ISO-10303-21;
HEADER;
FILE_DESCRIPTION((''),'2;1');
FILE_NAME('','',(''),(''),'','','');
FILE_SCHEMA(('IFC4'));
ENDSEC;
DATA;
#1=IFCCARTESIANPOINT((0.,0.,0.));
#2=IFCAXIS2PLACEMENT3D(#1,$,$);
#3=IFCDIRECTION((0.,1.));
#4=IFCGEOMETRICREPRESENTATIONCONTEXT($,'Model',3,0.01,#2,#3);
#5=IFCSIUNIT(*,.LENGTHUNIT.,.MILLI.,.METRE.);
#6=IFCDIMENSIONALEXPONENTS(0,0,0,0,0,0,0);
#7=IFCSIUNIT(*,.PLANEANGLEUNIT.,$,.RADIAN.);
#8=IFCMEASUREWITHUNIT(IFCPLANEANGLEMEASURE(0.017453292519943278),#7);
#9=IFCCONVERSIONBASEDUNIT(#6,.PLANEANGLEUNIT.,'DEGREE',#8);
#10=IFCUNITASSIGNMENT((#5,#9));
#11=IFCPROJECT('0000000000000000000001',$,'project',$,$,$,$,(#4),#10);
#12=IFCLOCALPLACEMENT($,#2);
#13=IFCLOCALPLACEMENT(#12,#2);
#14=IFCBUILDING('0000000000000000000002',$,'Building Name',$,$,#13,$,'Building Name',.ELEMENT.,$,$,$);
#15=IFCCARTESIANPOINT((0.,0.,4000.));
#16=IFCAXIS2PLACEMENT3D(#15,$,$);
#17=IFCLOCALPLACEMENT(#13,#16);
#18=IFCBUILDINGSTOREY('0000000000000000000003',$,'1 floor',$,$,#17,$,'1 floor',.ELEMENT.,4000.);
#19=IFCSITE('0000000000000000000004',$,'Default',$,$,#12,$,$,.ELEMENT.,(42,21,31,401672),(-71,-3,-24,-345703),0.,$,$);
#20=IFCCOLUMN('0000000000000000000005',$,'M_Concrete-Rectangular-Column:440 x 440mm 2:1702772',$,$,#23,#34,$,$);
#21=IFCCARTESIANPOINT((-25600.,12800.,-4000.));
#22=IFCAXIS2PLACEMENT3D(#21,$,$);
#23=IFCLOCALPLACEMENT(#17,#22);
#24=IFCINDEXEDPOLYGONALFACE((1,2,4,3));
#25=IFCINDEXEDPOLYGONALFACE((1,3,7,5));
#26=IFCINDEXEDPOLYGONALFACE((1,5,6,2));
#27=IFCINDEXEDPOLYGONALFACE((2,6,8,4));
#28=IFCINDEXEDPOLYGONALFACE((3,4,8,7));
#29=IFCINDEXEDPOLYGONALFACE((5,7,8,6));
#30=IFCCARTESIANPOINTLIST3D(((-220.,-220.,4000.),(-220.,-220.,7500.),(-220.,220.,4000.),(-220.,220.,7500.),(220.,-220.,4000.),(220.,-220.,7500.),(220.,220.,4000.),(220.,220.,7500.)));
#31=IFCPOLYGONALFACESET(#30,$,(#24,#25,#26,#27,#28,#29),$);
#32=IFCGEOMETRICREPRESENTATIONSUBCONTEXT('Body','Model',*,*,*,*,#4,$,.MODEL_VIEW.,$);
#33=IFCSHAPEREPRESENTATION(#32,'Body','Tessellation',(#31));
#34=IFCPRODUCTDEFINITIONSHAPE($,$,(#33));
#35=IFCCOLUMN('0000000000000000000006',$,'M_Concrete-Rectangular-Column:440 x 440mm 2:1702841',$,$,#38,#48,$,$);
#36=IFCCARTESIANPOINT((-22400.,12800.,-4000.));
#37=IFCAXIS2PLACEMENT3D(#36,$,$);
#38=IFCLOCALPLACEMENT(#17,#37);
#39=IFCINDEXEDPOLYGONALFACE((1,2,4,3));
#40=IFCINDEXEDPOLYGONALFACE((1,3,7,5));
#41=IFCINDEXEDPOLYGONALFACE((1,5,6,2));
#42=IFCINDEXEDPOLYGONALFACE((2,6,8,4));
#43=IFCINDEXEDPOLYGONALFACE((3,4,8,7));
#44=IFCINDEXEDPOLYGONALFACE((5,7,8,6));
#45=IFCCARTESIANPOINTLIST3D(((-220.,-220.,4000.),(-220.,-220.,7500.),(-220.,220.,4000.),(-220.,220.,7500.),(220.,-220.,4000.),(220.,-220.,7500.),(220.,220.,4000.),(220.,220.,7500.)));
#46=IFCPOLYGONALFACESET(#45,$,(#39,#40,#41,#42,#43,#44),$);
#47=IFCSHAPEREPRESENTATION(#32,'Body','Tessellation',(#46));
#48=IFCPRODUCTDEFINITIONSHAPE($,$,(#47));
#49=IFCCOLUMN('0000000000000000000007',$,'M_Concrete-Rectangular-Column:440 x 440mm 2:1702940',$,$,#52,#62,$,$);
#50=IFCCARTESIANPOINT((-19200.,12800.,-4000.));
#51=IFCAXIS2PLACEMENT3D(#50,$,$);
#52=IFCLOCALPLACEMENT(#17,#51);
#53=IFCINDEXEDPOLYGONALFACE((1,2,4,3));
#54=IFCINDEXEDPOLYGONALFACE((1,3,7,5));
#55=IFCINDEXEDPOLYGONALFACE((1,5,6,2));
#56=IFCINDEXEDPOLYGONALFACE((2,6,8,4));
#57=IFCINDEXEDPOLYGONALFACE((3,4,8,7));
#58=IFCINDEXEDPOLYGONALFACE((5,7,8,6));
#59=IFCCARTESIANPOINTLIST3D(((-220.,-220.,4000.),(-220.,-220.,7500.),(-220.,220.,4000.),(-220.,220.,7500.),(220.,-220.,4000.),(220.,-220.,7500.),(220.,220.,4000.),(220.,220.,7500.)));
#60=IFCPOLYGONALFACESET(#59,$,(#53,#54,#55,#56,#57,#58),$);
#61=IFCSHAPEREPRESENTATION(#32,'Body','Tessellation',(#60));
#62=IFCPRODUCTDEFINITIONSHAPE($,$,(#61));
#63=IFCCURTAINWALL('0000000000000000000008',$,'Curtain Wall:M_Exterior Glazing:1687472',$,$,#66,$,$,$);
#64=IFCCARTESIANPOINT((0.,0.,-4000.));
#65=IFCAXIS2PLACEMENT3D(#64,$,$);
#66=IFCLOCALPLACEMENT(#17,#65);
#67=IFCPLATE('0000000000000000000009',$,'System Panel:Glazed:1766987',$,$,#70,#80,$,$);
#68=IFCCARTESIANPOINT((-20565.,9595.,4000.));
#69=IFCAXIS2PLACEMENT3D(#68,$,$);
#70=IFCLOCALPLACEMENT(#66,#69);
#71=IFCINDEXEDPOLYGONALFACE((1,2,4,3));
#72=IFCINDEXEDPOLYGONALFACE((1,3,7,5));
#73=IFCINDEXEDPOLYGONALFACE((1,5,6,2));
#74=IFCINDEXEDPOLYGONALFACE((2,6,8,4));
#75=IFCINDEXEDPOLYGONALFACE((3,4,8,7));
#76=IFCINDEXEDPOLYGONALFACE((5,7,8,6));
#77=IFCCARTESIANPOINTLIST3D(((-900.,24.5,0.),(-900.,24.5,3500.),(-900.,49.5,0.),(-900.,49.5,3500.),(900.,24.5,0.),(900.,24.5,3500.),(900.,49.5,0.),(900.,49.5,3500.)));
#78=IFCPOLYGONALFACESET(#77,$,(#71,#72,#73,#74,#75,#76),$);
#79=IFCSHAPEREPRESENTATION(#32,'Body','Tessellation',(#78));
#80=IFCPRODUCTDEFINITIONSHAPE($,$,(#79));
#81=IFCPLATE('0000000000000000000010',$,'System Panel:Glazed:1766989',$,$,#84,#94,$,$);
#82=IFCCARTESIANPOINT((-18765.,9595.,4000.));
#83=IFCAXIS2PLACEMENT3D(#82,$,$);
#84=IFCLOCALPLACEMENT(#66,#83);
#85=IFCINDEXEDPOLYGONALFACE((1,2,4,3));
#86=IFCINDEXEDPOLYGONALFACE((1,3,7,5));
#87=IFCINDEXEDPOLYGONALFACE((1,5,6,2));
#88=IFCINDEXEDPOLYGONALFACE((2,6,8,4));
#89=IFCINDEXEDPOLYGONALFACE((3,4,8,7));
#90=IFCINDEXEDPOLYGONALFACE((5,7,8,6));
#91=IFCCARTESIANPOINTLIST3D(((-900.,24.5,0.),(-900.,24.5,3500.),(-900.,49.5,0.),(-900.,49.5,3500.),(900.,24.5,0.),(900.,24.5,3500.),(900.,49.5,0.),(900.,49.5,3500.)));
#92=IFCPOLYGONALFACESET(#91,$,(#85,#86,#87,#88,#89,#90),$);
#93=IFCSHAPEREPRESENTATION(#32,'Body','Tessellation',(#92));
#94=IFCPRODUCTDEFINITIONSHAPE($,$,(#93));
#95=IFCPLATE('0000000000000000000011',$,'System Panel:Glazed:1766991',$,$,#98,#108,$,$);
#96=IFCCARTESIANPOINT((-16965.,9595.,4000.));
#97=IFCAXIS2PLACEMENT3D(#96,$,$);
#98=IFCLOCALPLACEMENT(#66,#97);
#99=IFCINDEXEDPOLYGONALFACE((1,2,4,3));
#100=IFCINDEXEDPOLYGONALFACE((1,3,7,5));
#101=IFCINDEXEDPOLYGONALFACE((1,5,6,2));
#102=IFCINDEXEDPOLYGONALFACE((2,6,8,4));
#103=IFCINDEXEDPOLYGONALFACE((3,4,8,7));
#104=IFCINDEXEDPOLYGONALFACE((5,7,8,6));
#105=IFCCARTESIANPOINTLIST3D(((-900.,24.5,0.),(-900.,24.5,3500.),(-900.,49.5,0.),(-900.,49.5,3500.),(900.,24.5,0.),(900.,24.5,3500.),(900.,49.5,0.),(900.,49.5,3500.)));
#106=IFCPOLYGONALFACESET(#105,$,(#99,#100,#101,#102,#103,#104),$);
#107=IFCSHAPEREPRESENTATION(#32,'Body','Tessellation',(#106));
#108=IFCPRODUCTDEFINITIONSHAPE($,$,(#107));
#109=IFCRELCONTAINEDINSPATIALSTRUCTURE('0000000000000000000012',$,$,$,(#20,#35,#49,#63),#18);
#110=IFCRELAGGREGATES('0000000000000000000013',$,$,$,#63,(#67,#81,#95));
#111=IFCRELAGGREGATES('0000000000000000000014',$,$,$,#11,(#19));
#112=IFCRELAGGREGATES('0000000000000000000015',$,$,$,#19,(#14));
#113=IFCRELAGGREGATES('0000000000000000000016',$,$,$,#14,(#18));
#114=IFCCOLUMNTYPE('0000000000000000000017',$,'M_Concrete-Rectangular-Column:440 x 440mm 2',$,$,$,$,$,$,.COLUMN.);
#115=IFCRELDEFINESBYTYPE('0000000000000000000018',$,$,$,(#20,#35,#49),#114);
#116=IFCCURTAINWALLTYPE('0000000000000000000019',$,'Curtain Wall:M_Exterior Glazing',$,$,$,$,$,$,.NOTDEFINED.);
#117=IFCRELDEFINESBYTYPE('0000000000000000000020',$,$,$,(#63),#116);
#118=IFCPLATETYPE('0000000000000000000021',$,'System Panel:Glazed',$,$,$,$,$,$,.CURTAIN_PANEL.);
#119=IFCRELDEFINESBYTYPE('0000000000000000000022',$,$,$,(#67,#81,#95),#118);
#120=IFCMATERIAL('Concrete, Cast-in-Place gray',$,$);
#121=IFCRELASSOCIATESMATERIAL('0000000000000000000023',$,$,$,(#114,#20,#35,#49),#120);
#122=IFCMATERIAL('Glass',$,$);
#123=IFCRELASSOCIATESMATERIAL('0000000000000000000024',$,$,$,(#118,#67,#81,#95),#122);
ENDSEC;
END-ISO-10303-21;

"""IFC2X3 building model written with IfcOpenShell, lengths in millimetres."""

from ifc_helpers import new_model, entity, si_unit, converted_unit, direction, frame, origin, origin_2d_with_axis, place, context, subcontext, project, spatial, rectangle, extrude, source, transform, mapped, material, type_object, type_shapes, element, aggregate, save


model = new_model("IFC2X3")

# Units and contexts
model_context = context("Model", 3, precision=0.01, world=origin(), true_north=direction((0.0, 1.0)))
body_context = subcontext(model_context, "Body", "Model", "MODEL_VIEW")
ifc_project = project(units=[si_unit("LENGTHUNIT", "METRE", prefix="MILLI"), converted_unit("PLANEANGLEUNIT", "DEGREE", entity("IfcPlaneAngleMeasure", 0.017453292519943278), si_unit("PLANEANGLEUNIT", "RADIAN"), dimensions=[0, 0, 0, 0, 0, 0, 0])], contexts=[model_context])

# Site, building, storey
site_placement = place(None, origin())
site = spatial("IfcSite", under=ifc_project, at=site_placement, Name="Default", CompositionType="ELEMENT", RefLatitude=(42, 21, 31, 401672), RefLongitude=(-71, -3, -24, -345703), RefElevation=0.0)
building_placement = place(site_placement, origin())
building = spatial("IfcBuilding", under=site, at=building_placement, Name="Building Name", LongName="Building Name", CompositionType="ELEMENT")
storey_placement = place(building_placement, frame((0.0, 0.0, 4000.0)))
storey = spatial("IfcBuildingStorey", under=building, at=storey_placement, Name="1 floor", LongName="1 floor", CompositionType="ELEMENT", Elevation=4000.0)

# Columns
ifc_material_1 = material(Name="Concrete, Cast-in-Place gray")
column_type = type_object("IfcColumnType", Name="M_Concrete-Rectangular-Column:440 x 440mm 2", PredefinedType="COLUMN", material=ifc_material_1)
shared_shape_1 = source(origin(), body_context, "Body", "SweptSolid", [
    extrude(rectangle(XDim=440.0, YDim=440.0, at=origin_2d_with_axis()), frame((0.0, 0.0, 4000.0), z_axis=(0.0, 0.0, 1.0), x_axis=(-1.0, 0.0, 0.0)), (0.0, 0.0, 1.0), 3500.0),
])
type_shapes(column_type, [shared_shape_1])
for number, where, name in (
    (1, (-25600.0, 12800.0, -4000.0), "M_Concrete-Rectangular-Column:440 x 440mm 2:1702772"),
    (2, (-22400.0, 12800.0, -4000.0), "M_Concrete-Rectangular-Column:440 x 440mm 2:1702841"),
    (3, (-19200.0, 12800.0, -4000.0), "M_Concrete-Rectangular-Column:440 x 440mm 2:1702940"),
):
    element("IfcColumn", number, at=place(storey_placement, frame(where)), inside=storey, type_object=column_type, material=ifc_material_1, Name=name, context=body_context, shape_type="MappedRepresentation", body=[
        mapped(shared_shape_1, transform((0.0, 0.0, 0.0), scale=1.0)),
    ])

# Curtain wall, plates
curtain_wall_type = type_object("IfcCurtainWallType", Name="Curtain Wall:M_Exterior Glazing", PredefinedType="NOTDEFINED")
curtain_wall_placement = place(storey_placement, frame((0.0, 0.0, -4000.0)))
curtain_wall = element("IfcCurtainWall", 4, at=curtain_wall_placement, inside=storey, type_object=curtain_wall_type, Name="Curtain Wall:M_Exterior Glazing:1687472")
ifc_material_2 = material(Name="Glass")
plate_type = type_object("IfcPlateType", Name="System Panel:Glazed", PredefinedType="CURTAIN_PANEL", material=ifc_material_2)
shared_shape_2 = source(origin(), body_context, "Body", "SweptSolid", [
    extrude(rectangle(XDim=25.0, YDim=1800.0, at=origin_2d_with_axis()), frame((0.0, 37.0, 0.0), z_axis=(0.0, 0.0, 1.0), x_axis=(0.0, 1.0, 0.0)), (0.0, 0.0, 1.0), 3500.0),
])
type_shapes(plate_type, [shared_shape_2])
plate_1_placement = place(curtain_wall_placement, frame((-20565.0, 9595.0, 4000.0)))
plate_1 = element("IfcPlate", 5, at=plate_1_placement, type_object=plate_type, material=ifc_material_2, Name="System Panel:Glazed:1766987", context=body_context, shape_type="MappedRepresentation", body=[
    mapped(shared_shape_2, transform((0.0, 0.0, 0.0), scale=1.0)),
])
plate_2_placement = place(curtain_wall_placement, frame((-18765.0, 9595.0, 4000.0)))
plate_2 = element("IfcPlate", 6, at=plate_2_placement, type_object=plate_type, material=ifc_material_2, Name="System Panel:Glazed:1766989", context=body_context, shape_type="MappedRepresentation", body=[
    mapped(shared_shape_2, transform((0.0, 0.0, 0.0), scale=1.0)),
])
plate_3_placement = place(curtain_wall_placement, frame((-16965.0, 9595.0, 4000.0)))
plate_3 = element("IfcPlate", 7, at=plate_3_placement, type_object=plate_type, material=ifc_material_2, Name="System Panel:Glazed:1766991", context=body_context, shape_type="MappedRepresentation", body=[
    mapped(shared_shape_2, transform((0.0, 0.0, 0.0), scale=1.0)),
])
aggregate(curtain_wall, [plate_1, plate_2, plate_3])

save(model, "model.ifc")
